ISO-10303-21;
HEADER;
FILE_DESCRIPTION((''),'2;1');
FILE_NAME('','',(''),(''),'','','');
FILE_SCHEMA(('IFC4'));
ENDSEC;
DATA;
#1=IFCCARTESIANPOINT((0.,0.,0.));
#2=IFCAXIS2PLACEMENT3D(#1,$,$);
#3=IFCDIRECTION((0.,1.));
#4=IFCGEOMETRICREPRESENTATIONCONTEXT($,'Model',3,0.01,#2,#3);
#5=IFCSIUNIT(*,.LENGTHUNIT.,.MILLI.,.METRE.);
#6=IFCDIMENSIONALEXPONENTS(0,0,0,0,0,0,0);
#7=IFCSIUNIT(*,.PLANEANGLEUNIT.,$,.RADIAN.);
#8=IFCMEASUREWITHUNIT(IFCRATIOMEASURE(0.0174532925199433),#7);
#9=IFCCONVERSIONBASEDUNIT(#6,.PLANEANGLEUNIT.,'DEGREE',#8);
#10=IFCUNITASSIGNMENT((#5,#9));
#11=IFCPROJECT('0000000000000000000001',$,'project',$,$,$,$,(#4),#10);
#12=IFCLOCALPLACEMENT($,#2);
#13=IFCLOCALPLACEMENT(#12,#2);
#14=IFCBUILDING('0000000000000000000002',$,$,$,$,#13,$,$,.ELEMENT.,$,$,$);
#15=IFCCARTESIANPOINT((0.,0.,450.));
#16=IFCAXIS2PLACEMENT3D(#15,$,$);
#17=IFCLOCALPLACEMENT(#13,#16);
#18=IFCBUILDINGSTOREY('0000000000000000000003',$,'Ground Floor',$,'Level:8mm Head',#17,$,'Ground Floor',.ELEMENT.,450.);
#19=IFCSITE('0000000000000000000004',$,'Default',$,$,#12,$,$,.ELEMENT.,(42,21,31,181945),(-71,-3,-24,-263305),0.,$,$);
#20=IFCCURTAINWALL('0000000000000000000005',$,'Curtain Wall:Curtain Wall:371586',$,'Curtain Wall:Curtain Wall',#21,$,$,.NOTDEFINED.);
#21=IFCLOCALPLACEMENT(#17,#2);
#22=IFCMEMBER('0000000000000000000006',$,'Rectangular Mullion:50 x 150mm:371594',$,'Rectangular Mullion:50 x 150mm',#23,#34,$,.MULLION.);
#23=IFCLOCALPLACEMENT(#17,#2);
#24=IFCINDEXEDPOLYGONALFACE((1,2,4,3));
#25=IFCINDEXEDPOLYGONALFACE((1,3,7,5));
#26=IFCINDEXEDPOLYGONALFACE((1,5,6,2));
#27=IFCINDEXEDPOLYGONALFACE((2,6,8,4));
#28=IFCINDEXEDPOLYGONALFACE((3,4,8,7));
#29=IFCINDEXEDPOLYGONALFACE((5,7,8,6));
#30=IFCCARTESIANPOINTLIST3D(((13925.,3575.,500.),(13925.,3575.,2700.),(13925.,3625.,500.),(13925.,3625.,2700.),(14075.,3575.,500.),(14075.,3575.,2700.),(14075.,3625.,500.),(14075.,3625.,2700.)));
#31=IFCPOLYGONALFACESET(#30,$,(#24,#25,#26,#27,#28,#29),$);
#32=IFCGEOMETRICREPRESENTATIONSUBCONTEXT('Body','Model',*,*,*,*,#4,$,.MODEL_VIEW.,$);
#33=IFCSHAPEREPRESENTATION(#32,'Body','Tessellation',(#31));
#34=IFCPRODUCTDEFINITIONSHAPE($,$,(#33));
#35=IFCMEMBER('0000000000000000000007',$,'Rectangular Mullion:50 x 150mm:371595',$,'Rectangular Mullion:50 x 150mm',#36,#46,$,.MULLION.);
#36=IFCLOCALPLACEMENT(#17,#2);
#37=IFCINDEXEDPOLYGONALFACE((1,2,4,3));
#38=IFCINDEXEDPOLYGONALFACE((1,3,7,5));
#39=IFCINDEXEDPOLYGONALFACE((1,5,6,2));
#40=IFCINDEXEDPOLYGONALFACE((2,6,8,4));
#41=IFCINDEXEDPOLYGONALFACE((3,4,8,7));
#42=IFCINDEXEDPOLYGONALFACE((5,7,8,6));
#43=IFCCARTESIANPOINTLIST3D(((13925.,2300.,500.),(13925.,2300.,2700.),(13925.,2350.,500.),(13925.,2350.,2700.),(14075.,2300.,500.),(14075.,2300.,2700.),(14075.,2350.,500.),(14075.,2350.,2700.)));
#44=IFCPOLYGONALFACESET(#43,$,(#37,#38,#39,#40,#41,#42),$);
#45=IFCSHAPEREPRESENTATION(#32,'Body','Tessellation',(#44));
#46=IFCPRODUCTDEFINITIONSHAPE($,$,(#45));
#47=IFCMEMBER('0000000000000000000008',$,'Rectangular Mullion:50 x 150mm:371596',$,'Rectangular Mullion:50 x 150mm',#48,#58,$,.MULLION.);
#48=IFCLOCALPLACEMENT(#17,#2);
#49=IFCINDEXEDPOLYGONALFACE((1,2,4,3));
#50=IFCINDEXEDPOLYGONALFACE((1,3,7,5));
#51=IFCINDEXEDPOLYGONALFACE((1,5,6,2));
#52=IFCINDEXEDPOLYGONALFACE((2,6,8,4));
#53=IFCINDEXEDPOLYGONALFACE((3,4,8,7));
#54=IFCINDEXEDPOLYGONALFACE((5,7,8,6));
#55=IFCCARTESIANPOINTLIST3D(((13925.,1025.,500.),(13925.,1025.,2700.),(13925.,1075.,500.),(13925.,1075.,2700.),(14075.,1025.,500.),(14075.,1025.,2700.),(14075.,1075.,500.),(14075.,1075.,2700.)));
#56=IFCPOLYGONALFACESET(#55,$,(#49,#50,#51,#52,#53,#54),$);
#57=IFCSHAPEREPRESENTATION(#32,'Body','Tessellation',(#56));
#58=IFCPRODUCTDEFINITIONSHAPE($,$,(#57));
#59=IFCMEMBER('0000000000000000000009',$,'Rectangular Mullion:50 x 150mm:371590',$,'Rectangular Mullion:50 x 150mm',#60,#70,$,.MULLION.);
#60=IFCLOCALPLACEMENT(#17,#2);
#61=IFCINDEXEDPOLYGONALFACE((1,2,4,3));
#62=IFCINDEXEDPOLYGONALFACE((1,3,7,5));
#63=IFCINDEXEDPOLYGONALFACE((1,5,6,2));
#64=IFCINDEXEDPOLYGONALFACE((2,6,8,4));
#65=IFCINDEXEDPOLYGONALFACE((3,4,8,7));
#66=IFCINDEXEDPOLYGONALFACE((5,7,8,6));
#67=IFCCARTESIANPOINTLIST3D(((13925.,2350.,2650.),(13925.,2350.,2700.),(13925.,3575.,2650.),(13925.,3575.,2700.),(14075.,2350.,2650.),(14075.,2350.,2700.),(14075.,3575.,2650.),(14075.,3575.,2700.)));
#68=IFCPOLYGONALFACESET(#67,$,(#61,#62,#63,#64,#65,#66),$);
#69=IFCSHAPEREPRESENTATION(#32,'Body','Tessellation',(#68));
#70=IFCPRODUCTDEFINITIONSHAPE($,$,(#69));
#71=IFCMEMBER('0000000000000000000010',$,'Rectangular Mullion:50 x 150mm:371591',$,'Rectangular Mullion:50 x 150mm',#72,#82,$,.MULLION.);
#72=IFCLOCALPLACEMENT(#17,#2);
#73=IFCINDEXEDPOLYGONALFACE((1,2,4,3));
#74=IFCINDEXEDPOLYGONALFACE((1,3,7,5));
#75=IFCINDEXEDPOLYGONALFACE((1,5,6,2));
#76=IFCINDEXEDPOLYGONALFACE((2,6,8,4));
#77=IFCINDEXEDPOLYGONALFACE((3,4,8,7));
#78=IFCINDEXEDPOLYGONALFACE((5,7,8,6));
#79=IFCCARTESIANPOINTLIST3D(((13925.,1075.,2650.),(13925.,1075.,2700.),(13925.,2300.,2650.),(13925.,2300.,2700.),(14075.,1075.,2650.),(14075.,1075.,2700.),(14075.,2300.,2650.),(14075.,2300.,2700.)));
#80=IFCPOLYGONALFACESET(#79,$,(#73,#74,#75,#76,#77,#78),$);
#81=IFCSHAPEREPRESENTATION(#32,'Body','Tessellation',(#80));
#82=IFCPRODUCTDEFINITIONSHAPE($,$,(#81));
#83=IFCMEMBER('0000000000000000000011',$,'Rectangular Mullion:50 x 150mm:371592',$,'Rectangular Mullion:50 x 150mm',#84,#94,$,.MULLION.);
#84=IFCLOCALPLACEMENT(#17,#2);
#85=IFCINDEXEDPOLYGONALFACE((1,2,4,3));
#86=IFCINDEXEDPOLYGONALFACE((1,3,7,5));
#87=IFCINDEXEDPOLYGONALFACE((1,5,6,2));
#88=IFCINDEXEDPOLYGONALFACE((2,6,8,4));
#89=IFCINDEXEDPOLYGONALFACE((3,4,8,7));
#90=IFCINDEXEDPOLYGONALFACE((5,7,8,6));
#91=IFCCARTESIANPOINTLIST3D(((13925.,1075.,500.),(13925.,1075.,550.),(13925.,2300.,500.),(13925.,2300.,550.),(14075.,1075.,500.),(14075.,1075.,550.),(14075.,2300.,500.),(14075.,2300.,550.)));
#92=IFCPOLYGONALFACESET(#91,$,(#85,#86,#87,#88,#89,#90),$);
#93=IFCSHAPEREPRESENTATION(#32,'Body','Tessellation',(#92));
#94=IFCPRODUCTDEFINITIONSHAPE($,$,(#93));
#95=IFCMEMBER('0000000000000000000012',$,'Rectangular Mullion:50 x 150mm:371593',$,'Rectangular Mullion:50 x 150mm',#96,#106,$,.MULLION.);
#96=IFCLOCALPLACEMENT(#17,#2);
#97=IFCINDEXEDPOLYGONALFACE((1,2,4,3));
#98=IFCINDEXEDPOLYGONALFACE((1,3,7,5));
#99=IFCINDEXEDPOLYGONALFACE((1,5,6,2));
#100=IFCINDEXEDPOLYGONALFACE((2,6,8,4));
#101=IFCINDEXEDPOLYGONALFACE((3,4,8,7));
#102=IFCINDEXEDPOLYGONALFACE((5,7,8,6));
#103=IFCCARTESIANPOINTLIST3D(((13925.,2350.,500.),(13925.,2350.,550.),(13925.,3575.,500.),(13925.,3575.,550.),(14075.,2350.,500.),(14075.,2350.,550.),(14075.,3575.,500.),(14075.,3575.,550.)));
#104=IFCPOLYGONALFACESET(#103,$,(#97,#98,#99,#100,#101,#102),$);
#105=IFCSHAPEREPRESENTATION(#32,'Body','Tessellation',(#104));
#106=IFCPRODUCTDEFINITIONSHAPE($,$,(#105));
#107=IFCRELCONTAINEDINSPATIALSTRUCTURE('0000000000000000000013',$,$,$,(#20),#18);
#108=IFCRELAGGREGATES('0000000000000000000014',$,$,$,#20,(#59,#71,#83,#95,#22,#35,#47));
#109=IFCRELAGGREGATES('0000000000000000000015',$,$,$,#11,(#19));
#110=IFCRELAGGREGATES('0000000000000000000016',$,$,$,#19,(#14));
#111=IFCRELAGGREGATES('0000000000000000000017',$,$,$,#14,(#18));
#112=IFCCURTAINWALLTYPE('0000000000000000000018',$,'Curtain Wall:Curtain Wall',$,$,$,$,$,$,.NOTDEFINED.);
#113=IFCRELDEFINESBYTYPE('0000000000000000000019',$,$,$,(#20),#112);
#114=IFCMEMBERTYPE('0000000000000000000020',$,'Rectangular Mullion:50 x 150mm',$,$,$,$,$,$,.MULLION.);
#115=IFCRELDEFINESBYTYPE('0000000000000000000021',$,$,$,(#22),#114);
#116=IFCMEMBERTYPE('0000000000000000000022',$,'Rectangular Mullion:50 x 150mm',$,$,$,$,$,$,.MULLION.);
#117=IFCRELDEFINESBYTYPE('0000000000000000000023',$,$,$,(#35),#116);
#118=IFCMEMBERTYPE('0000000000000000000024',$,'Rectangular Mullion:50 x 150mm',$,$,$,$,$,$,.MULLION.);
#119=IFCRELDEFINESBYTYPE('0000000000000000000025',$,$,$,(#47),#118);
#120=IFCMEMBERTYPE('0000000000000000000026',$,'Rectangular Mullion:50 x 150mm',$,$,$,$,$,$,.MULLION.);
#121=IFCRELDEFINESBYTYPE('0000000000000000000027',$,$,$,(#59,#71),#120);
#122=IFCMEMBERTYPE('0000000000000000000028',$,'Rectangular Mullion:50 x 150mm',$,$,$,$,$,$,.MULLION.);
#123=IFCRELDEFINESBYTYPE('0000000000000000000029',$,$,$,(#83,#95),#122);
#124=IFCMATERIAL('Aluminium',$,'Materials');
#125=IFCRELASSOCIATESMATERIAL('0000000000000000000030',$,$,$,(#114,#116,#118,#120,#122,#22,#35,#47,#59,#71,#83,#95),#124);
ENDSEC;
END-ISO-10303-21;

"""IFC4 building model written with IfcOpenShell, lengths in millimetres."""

from ifc_helpers import new_model, entity, si_unit, converted_unit, direction, frame, origin, origin_2d_with_axis, place, context, subcontext, project, spatial, rectangle, extrude, source, transform, mapped, material, material_profile, profile_set, profile_usage, type_object, type_shapes, element, aggregate, save


model = new_model("IFC4")

# Units and contexts
model_context = context("Model", 3, precision=0.01, world=origin(), true_north=direction((0.0, 1.0)))
body_context = subcontext(model_context, "Body", "Model", "MODEL_VIEW")
ifc_project = project(units=[si_unit("LENGTHUNIT", "METRE", prefix="MILLI"), converted_unit("PLANEANGLEUNIT", "DEGREE", entity("IfcRatioMeasure", 0.0174532925199433), si_unit("PLANEANGLEUNIT", "RADIAN"), dimensions=[0, 0, 0, 0, 0, 0, 0])], contexts=[model_context])

# Site, building, storey
site_placement = place(None, origin())
site = spatial("IfcSite", under=ifc_project, at=site_placement, Name="Default", CompositionType="ELEMENT", RefLatitude=(42, 21, 31, 181945), RefLongitude=(-71, -3, -24, -263305), RefElevation=0.0)
building_placement = place(site_placement, origin())
building = spatial("IfcBuilding", under=site, at=building_placement, CompositionType="ELEMENT")
storey_placement = place(building_placement, frame((0.0, 0.0, 450.0)))
storey = spatial("IfcBuildingStorey", under=building, at=storey_placement, Name="Ground Floor", ObjectType="Level:8mm Head", LongName="Ground Floor", CompositionType="ELEMENT", Elevation=450.0)

# Curtain wall, members
curtain_wall_type = type_object("IfcCurtainWallType", Name="Curtain Wall:Curtain Wall", PredefinedType="NOTDEFINED")
curtain_wall_placement = place(storey_placement, frame((0.0, 0.0, -450.0)))
curtain_wall = element("IfcCurtainWall", 1, at=curtain_wall_placement, inside=storey, type_object=curtain_wall_type, Name="Curtain Wall:Curtain Wall:371586", ObjectType="Curtain Wall:Curtain Wall", PredefinedType="NOTDEFINED")
ifc_material_1 = material(Name="Aluminium", Category="Materials")
ifc_material_profile = material_profile(ifc_material_1, rectangle(XDim=150.0, YDim=50.0, at=origin_2d_with_axis()), Name="50 x 150mm")
ifc_profile_set = profile_set([ifc_material_profile], Name="50 x 150mm")
ifc_profile_usage_1 = profile_usage(ifc_profile_set)
member_type_1 = type_object("IfcMemberType", Name="Rectangular Mullion:50 x 150mm", PredefinedType="MULLION", material=ifc_profile_set)
shared_shape_1 = source(origin(), body_context, "Body", "SweptSolid", [
    extrude(rectangle(XDim=150.0, YDim=50.0, at=origin_2d_with_axis()), frame((-25.0, 0.0, -2200.0), z_axis=(0.0, 0.0, 1.0), x_axis=(0.0, -1.0, 0.0)), (0.0, 0.0, 1.0), 2200.0),
])
type_shapes(member_type_1, [shared_shape_1])
member_1_placement = place(storey_placement, frame((14000.0, 3625.0, 500.0), z_axis=(0.0, 0.0, -1.0), x_axis=(0.0, 1.0, 0.0)))
member_1 = element("IfcMember", 2, at=member_1_placement, type_object=member_type_1, material=ifc_profile_usage_1, Name="Rectangular Mullion:50 x 150mm:371594", ObjectType="Rectangular Mullion:50 x 150mm", PredefinedType="MULLION", context=body_context, shape_type="MappedRepresentation", body=[
    mapped(shared_shape_1, transform((0.0, 0.0, 0.0), scale=1.0)),
])
ifc_profile_usage_2 = profile_usage(ifc_profile_set)
member_type_2 = type_object("IfcMemberType", Name="Rectangular Mullion:50 x 150mm", PredefinedType="MULLION", material=ifc_profile_set)
shared_shape_2 = source(origin(), body_context, "Body", "SweptSolid", [
    extrude(rectangle(XDim=150.0, YDim=50.0, at=origin_2d_with_axis()), frame((0.0, 0.0, -2200.0), z_axis=(0.0, 0.0, 1.0), x_axis=(0.0, -1.0, 0.0)), (0.0, 0.0, 1.0), 2200.0),
])
type_shapes(member_type_2, [shared_shape_2])
member_2_placement = place(storey_placement, frame((14000.0, 2325.0, 500.0), z_axis=(0.0, 0.0, -1.0), x_axis=(0.0, 1.0, 0.0)))
member_2 = element("IfcMember", 3, at=member_2_placement, type_object=member_type_2, material=ifc_profile_usage_2, Name="Rectangular Mullion:50 x 150mm:371595", ObjectType="Rectangular Mullion:50 x 150mm", PredefinedType="MULLION", context=body_context, shape_type="MappedRepresentation", body=[
    mapped(shared_shape_2, transform((0.0, 0.0, 0.0), scale=1.0)),
])
ifc_profile_usage_3 = profile_usage(ifc_profile_set)
member_type_3 = type_object("IfcMemberType", Name="Rectangular Mullion:50 x 150mm", PredefinedType="MULLION", material=ifc_profile_set)
shared_shape_3 = source(origin(), body_context, "Body", "SweptSolid", [
    extrude(rectangle(XDim=150.0, YDim=50.0, at=origin_2d_with_axis()), frame((-25.0, 0.0, -2200.0), z_axis=(0.0, 0.0, 1.0), x_axis=(0.0, -1.0, 0.0)), (0.0, 0.0, 1.0), 2200.0),
])
type_shapes(member_type_3, [shared_shape_3])
member_3_placement = place(storey_placement, frame((14000.0, 1025.0, 2700.0), z_axis=(0.0, 0.0, 1.0), x_axis=(0.0, -1.0, 0.0)))
member_3 = element("IfcMember", 4, at=member_3_placement, type_object=member_type_3, material=ifc_profile_usage_3, Name="Rectangular Mullion:50 x 150mm:371596", ObjectType="Rectangular Mullion:50 x 150mm", PredefinedType="MULLION", context=body_context, shape_type="MappedRepresentation", body=[
    mapped(shared_shape_3, transform((0.0, 0.0, 0.0), scale=1.0)),
])
ifc_profile_usage_4 = profile_usage(ifc_profile_set)
member_type_4 = type_object("IfcMemberType", Name="Rectangular Mullion:50 x 150mm", PredefinedType="MULLION", material=ifc_profile_set)
shared_shape_4 = source(origin(), body_context, "Body", "SweptSolid", [
    extrude(rectangle(XDim=150.0, YDim=50.0, at=origin_2d_with_axis()), frame((-25.0, 0.0, -1225.0), z_axis=(0.0, 0.0, 1.0), x_axis=(0.0, -1.0, 0.0)), (0.0, 0.0, 1.0), 1225.0),
])
type_shapes(member_type_4, [shared_shape_4])
member_4_placement = place(storey_placement, frame((14000.0, 3575.0, 2700.0), z_axis=(0.0, 1.0, 0.0), x_axis=(0.0, 0.0, 1.0)))
member_4 = element("IfcMember", 5, at=member_4_placement, type_object=member_type_4, material=ifc_profile_usage_4, Name="Rectangular Mullion:50 x 150mm:371590", ObjectType="Rectangular Mullion:50 x 150mm", PredefinedType="MULLION", context=body_context, shape_type="MappedRepresentation", body=[
    mapped(shared_shape_4, transform((0.0, 0.0, 0.0), scale=1.0)),
])
ifc_profile_usage_5 = profile_usage(ifc_profile_set)
member_5_placement = place(storey_placement, frame((14000.0, 2300.0, 2700.0), z_axis=(0.0, 1.0, 0.0), x_axis=(0.0, 0.0, 1.0)))
member_5 = element("IfcMember", 6, at=member_5_placement, type_object=member_type_4, material=ifc_profile_usage_5, Name="Rectangular Mullion:50 x 150mm:371591", ObjectType="Rectangular Mullion:50 x 150mm", PredefinedType="MULLION", context=body_context, shape_type="MappedRepresentation", body=[
    mapped(shared_shape_4, transform((0.0, 0.0, 0.0), scale=1.0)),
])
ifc_profile_usage_6 = profile_usage(ifc_profile_set)
member_type_5 = type_object("IfcMemberType", Name="Rectangular Mullion:50 x 150mm", PredefinedType="MULLION", material=ifc_profile_set)
shared_shape_5 = source(origin(), body_context, "Body", "SweptSolid", [
    extrude(rectangle(XDim=150.0, YDim=50.0, at=origin_2d_with_axis()), frame((-25.0, 0.0, -1225.0), z_axis=(0.0, 0.0, 1.0), x_axis=(0.0, -1.0, 0.0)), (0.0, 0.0, 1.0), 1225.0),
])
type_shapes(member_type_5, [shared_shape_5])
member_6_placement = place(storey_placement, frame((14000.0, 1075.0, 500.0), z_axis=(0.0, -1.0, 0.0), x_axis=(0.0, 0.0, -1.0)))
member_6 = element("IfcMember", 7, at=member_6_placement, type_object=member_type_5, material=ifc_profile_usage_6, Name="Rectangular Mullion:50 x 150mm:371592", ObjectType="Rectangular Mullion:50 x 150mm", PredefinedType="MULLION", context=body_context, shape_type="MappedRepresentation", body=[
    mapped(shared_shape_5, transform((0.0, 0.0, 0.0), scale=1.0)),
])
ifc_profile_usage_7 = profile_usage(ifc_profile_set)
member_7_placement = place(storey_placement, frame((14000.0, 2350.0, 500.0), z_axis=(0.0, -1.0, 0.0), x_axis=(0.0, 0.0, -1.0)))
member_7 = element("IfcMember", 8, at=member_7_placement, type_object=member_type_5, material=ifc_profile_usage_7, Name="Rectangular Mullion:50 x 150mm:371593", ObjectType="Rectangular Mullion:50 x 150mm", PredefinedType="MULLION", context=body_context, shape_type="MappedRepresentation", body=[
    mapped(shared_shape_5, transform((0.0, 0.0, 0.0), scale=1.0)),
])
aggregate(curtain_wall, [member_4, member_5, member_6, member_7, member_1, member_2, member_3])

save(model, "model.ifc")
